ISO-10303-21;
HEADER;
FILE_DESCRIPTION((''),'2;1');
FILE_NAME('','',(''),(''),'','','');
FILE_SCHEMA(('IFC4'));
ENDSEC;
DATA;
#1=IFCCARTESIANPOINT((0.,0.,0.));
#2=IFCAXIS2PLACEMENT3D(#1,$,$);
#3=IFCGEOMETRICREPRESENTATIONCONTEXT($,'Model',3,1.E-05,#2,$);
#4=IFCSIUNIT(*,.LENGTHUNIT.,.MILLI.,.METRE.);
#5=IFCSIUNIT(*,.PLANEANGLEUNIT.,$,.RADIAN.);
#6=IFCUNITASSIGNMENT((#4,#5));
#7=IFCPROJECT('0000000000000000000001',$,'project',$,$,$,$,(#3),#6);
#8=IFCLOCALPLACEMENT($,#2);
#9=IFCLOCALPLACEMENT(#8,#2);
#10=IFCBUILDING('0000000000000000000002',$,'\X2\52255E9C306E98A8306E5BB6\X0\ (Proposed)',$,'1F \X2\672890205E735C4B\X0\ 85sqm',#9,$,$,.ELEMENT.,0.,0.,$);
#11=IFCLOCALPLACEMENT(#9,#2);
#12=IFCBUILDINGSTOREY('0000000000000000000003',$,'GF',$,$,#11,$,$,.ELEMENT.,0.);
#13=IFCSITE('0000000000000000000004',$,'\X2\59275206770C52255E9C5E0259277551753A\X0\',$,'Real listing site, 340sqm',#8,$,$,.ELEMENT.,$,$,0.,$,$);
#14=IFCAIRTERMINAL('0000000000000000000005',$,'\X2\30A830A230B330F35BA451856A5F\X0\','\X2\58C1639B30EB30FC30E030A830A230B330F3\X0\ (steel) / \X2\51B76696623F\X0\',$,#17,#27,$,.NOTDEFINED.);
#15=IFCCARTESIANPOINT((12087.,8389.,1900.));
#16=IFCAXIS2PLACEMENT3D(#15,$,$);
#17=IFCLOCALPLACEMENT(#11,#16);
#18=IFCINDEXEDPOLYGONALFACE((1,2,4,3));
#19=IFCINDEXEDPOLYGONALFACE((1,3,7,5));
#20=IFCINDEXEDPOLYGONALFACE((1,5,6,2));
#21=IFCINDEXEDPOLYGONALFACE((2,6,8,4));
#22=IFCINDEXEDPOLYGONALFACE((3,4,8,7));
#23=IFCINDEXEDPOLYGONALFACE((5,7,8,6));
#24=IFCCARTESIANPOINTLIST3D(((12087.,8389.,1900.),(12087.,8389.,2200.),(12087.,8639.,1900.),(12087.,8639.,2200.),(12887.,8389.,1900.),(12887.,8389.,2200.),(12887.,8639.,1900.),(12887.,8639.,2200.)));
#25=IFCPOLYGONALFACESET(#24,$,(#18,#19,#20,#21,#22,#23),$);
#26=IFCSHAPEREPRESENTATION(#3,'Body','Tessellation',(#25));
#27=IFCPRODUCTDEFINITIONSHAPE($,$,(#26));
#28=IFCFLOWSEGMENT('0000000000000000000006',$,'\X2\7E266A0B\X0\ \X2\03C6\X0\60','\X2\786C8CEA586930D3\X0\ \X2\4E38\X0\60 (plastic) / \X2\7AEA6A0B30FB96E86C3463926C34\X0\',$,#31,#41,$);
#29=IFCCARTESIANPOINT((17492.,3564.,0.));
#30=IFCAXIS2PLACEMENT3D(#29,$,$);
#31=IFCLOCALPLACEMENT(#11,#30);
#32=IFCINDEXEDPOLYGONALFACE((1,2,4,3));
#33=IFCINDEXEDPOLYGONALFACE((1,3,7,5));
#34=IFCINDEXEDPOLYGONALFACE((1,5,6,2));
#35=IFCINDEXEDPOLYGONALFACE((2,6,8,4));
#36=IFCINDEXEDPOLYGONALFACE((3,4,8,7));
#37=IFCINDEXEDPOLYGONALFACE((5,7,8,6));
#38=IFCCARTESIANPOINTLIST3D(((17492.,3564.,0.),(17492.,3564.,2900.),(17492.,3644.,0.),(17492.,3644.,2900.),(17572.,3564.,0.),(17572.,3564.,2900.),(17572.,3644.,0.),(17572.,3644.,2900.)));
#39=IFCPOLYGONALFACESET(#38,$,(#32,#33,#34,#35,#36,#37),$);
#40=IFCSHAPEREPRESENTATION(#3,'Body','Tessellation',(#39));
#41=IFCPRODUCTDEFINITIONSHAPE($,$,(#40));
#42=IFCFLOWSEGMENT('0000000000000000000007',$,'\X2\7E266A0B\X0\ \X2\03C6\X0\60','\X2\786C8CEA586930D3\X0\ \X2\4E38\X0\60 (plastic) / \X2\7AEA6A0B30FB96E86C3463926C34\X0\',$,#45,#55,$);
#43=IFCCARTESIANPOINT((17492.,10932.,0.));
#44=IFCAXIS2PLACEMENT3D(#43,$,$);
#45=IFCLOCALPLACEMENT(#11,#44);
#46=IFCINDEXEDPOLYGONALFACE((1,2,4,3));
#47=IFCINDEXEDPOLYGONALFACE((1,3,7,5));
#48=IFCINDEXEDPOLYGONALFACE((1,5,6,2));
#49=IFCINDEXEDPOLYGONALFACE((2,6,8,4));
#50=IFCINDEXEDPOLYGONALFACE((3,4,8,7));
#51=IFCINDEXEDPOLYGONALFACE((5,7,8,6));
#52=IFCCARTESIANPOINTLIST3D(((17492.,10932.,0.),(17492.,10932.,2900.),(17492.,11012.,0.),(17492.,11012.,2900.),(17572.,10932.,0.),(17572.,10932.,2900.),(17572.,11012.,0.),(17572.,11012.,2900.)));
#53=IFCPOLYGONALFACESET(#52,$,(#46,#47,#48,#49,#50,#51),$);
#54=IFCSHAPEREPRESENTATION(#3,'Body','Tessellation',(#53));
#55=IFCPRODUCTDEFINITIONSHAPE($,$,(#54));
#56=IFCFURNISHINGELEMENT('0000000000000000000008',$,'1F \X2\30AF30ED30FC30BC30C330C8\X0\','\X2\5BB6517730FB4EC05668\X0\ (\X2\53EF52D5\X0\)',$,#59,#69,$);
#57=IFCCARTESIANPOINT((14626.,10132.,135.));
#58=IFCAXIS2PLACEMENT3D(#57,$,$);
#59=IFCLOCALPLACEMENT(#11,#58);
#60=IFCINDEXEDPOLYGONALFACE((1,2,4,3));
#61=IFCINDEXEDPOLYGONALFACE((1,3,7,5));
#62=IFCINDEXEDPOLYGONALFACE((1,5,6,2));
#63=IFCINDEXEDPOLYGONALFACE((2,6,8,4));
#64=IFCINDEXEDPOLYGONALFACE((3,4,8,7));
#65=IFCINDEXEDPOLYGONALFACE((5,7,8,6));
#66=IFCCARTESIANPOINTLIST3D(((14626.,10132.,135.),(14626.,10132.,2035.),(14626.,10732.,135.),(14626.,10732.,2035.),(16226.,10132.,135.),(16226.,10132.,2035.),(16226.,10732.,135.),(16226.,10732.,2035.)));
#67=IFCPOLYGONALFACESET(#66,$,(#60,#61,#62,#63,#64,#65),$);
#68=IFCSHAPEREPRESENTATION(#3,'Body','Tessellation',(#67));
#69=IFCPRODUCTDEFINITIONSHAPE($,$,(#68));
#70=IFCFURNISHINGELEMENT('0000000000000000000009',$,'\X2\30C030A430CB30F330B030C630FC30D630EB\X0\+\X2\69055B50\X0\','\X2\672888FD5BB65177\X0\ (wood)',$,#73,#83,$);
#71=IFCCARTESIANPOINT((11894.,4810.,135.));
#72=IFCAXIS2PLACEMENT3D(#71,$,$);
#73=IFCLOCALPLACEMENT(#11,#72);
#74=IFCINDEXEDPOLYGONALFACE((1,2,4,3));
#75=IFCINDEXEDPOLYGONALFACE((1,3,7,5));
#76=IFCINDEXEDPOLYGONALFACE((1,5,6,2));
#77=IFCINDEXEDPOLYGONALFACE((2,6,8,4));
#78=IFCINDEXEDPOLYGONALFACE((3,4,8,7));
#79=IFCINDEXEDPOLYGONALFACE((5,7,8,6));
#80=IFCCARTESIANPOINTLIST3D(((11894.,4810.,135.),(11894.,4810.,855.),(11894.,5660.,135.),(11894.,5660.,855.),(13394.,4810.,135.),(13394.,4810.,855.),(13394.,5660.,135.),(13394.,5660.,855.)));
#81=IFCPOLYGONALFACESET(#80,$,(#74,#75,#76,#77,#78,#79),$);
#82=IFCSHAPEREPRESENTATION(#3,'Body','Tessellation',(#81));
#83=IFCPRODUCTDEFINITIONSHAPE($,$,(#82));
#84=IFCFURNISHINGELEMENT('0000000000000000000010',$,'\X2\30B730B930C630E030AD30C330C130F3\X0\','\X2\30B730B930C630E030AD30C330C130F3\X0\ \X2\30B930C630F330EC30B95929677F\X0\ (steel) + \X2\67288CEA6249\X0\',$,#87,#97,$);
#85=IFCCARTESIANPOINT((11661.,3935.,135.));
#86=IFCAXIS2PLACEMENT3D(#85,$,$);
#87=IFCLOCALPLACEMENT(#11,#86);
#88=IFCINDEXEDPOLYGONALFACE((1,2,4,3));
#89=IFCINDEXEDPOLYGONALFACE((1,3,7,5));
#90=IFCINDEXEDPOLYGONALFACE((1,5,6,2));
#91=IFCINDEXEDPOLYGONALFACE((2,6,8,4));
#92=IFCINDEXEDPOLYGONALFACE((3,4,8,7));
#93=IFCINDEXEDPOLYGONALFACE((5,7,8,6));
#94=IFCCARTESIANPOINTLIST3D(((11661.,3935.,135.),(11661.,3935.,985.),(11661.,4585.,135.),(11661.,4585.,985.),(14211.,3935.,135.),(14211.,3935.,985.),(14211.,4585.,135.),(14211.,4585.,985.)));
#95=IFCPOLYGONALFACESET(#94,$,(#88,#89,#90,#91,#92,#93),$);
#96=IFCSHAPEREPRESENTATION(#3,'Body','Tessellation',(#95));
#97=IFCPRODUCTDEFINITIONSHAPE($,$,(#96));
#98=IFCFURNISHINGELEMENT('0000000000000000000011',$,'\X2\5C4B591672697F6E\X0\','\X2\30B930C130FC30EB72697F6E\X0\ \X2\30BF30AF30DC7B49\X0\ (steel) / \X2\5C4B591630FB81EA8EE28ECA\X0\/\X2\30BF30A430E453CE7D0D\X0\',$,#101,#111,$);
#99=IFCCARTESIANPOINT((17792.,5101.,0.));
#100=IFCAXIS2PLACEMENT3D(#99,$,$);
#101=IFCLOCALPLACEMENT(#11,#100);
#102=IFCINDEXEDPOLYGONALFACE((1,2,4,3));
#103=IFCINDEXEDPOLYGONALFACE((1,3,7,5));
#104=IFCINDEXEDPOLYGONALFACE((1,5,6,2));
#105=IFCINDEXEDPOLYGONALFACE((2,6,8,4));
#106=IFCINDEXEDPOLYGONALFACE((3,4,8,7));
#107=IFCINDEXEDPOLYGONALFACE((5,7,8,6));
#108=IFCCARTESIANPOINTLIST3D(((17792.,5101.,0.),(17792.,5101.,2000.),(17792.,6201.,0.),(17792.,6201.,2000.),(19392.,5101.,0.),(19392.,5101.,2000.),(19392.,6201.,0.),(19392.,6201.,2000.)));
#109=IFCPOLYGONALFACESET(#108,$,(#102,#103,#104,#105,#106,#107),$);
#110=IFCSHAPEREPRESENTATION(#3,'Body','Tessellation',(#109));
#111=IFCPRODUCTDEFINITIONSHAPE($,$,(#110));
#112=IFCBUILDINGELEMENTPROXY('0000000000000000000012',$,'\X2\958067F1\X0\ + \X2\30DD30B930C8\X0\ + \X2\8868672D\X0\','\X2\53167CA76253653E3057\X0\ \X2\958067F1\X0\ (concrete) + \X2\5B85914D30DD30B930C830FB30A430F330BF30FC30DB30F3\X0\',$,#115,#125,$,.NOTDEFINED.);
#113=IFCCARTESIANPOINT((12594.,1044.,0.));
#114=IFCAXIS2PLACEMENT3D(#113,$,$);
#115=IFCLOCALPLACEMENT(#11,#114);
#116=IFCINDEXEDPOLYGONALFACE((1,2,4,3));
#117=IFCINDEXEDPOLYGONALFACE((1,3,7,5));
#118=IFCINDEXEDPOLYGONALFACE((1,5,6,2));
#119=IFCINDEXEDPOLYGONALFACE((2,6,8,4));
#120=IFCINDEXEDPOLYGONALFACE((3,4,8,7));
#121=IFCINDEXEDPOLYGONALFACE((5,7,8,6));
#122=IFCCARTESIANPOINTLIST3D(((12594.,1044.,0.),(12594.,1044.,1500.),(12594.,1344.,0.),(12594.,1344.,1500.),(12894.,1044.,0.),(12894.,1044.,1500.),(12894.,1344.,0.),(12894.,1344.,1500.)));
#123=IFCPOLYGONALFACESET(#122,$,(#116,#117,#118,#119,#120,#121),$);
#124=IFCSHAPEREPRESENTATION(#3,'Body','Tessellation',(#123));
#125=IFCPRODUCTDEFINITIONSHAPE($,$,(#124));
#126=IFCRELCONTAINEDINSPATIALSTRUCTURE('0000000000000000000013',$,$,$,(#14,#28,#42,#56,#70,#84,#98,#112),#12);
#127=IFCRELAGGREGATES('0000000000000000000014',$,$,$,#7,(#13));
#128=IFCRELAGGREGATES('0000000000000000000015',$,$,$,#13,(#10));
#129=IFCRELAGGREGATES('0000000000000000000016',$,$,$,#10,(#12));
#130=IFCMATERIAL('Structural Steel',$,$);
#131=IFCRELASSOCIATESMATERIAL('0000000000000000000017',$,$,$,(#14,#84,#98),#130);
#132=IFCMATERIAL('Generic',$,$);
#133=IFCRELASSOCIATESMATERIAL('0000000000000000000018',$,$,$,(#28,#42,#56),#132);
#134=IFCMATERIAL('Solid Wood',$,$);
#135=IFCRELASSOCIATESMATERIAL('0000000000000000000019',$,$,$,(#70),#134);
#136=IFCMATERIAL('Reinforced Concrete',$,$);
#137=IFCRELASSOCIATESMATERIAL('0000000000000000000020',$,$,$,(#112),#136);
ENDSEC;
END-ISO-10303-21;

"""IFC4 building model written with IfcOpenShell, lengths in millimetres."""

from ifc_helpers import new_model, si_unit, frame, frame_2d, origin, place, context, project, spatial, rectangle, extrude, material, element, save


model = new_model("IFC4")

# Units and contexts
model_context = context("Model", 3, precision=1e-05, world=origin())
ifc_project = project(units=[si_unit("LENGTHUNIT", "METRE", prefix="MILLI"), si_unit("PLANEANGLEUNIT", "RADIAN")], contexts=[model_context])

# Site, building, storey
site_placement = place(None, origin())
site = spatial("IfcSite", under=ifc_project, at=site_placement, Name="大分県別府市大畑町", ObjectType="Real listing site, 340sqm", CompositionType="ELEMENT", RefElevation=0.0)
building_placement = place(site_placement, origin())
building = spatial("IfcBuilding", under=site, at=building_placement, Name="別府の風の家 (Proposed)", ObjectType="1F 木造平屋 85sqm", CompositionType="ELEMENT", ElevationOfRefHeight=0.0, ElevationOfTerrain=0.0)
storey_placement = place(building_placement, origin())
storey = spatial("IfcBuildingStorey", under=building, at=storey_placement, Name="GF", CompositionType="ELEMENT", Elevation=0.0)

# Shared definitions
ifc_material_1 = material(Name="Solid Wood")

# Shared definitions
ifc_material_2 = material(Name="Reinforced Concrete")

# Shared definitions
ifc_material_3 = material(Name="Generic")

# Shared definitions
ifc_material_4 = material(Name="Structural Steel")

# Air terminal
air_terminal_placement = place(storey_placement, frame((12087.0, 8389.0, 1900.0)))
element("IfcAirTerminal", 1, at=air_terminal_placement, inside=storey, material=ifc_material_4, Name="エアコン室内機", Description="壁掛ルームエアコン (steel) / 冷暖房", PredefinedType="NOTDEFINED", context=model_context, shape_type="SweptSolid", body=[
    extrude(rectangle(XDim=800.0, YDim=250.0, at=frame_2d((400.0, 125.0))), frame((12087.0, 8389.0, 1900.0)), (0.0, 0.0, 1.0), 300.0),
])

# Flow segments
flow_segment_1_placement = place(storey_placement, frame((17492.0, 3564.0, 0.0)))
element("IfcFlowSegment", 2, at=flow_segment_1_placement, inside=storey, material=ifc_material_3, Name="縦樋 φ60", Description="硬質塩ビ 丸60 (plastic) / 竪樋・雨水排水", context=model_context, shape_type="SweptSolid", body=[
    extrude(rectangle(XDim=80.0, YDim=80.0, at=frame_2d((40.0, 40.0))), frame((17492.0, 3564.0, 0.0)), (0.0, 0.0, 1.0), 2900.0),
])
flow_segment_2_placement = place(storey_placement, frame((17492.0, 10932.0, 0.0)))
element("IfcFlowSegment", 3, at=flow_segment_2_placement, inside=storey, material=ifc_material_3, Name="縦樋 φ60", Description="硬質塩ビ 丸60 (plastic) / 竪樋・雨水排水", context=model_context, shape_type="SweptSolid", body=[
    extrude(rectangle(XDim=80.0, YDim=80.0, at=frame_2d((40.0, 40.0))), frame((17492.0, 10932.0, 0.0)), (0.0, 0.0, 1.0), 2900.0),
])

# Furnishing elements
furnishing_1_placement = place(storey_placement, frame((14626.0, 10132.0, 135.0)))
element("IfcFurnishingElement", 4, at=furnishing_1_placement, inside=storey, material=ifc_material_3, Name="1F クローゼット", Description="家具・什器 (可動)", context=model_context, shape_type="SweptSolid", body=[
    extrude(rectangle(XDim=1600.0, YDim=600.0, at=frame_2d((800.0, 300.0))), frame((14626.0, 10132.0, 135.0)), (0.0, 0.0, 1.0), 1900.0),
])
furnishing_2_placement = place(storey_placement, frame((11894.0, 4810.0, 135.0)))
element("IfcFurnishingElement", 5, at=furnishing_2_placement, inside=storey, material=ifc_material_1, Name="ダイニングテーブル+椅子", Description="木製家具 (wood)", context=model_context, shape_type="SweptSolid", body=[
    extrude(rectangle(XDim=1500.0, YDim=850.0, at=frame_2d((750.0, 425.0))), frame((11894.0, 4810.0, 135.0)), (0.0, 0.0, 1.0), 720.0),
])
furnishing_3_placement = place(storey_placement, frame((11661.0, 3935.0, 135.0)))
element("IfcFurnishingElement", 6, at=furnishing_3_placement, inside=storey, material=ifc_material_4, Name="システムキッチン", Description="システムキッチン ステンレス天板 (steel) + 木質扉", context=model_context, shape_type="SweptSolid", body=[
    extrude(rectangle(XDim=2550.0, YDim=650.0, at=frame_2d((1275.0, 325.0))), frame((11661.0, 3935.0, 135.0)), (0.0, 0.0, 1.0), 850.0),
])
furnishing_4_placement = place(storey_placement, frame((17792.0, 5101.0, 0.0)))
element("IfcFurnishingElement", 7, at=furnishing_4_placement, inside=storey, material=ifc_material_4, Name="屋外物置", Description="スチール物置 タクボ等 (steel) / 屋外・自転車/タイヤ収納", context=model_context, shape_type="SweptSolid", body=[
    extrude(rectangle(XDim=1600.0, YDim=1100.0, at=frame_2d((800.0, 550.0))), frame((17792.0, 5101.0, 0.0)), (0.0, 0.0, 1.0), 2000.0),
])

# Building element proxy
proxy_placement = place(storey_placement, frame((12594.0, 1044.0, 0.0)))
element("IfcBuildingElementProxy", 8, at=proxy_placement, inside=storey, material=ifc_material_2, Name="門柱 + ポスト + 表札", Description="化粧打放し 門柱 (concrete) + 宅配ポスト・インターホン", PredefinedType="NOTDEFINED", context=model_context, shape_type="SweptSolid", body=[
    extrude(rectangle(XDim=300.0, YDim=300.0, at=frame_2d((150.0, 150.0))), frame((12594.0, 1044.0, 0.0)), (0.0, 0.0, 1.0), 1500.0),
])

save(model, "model.ifc")
